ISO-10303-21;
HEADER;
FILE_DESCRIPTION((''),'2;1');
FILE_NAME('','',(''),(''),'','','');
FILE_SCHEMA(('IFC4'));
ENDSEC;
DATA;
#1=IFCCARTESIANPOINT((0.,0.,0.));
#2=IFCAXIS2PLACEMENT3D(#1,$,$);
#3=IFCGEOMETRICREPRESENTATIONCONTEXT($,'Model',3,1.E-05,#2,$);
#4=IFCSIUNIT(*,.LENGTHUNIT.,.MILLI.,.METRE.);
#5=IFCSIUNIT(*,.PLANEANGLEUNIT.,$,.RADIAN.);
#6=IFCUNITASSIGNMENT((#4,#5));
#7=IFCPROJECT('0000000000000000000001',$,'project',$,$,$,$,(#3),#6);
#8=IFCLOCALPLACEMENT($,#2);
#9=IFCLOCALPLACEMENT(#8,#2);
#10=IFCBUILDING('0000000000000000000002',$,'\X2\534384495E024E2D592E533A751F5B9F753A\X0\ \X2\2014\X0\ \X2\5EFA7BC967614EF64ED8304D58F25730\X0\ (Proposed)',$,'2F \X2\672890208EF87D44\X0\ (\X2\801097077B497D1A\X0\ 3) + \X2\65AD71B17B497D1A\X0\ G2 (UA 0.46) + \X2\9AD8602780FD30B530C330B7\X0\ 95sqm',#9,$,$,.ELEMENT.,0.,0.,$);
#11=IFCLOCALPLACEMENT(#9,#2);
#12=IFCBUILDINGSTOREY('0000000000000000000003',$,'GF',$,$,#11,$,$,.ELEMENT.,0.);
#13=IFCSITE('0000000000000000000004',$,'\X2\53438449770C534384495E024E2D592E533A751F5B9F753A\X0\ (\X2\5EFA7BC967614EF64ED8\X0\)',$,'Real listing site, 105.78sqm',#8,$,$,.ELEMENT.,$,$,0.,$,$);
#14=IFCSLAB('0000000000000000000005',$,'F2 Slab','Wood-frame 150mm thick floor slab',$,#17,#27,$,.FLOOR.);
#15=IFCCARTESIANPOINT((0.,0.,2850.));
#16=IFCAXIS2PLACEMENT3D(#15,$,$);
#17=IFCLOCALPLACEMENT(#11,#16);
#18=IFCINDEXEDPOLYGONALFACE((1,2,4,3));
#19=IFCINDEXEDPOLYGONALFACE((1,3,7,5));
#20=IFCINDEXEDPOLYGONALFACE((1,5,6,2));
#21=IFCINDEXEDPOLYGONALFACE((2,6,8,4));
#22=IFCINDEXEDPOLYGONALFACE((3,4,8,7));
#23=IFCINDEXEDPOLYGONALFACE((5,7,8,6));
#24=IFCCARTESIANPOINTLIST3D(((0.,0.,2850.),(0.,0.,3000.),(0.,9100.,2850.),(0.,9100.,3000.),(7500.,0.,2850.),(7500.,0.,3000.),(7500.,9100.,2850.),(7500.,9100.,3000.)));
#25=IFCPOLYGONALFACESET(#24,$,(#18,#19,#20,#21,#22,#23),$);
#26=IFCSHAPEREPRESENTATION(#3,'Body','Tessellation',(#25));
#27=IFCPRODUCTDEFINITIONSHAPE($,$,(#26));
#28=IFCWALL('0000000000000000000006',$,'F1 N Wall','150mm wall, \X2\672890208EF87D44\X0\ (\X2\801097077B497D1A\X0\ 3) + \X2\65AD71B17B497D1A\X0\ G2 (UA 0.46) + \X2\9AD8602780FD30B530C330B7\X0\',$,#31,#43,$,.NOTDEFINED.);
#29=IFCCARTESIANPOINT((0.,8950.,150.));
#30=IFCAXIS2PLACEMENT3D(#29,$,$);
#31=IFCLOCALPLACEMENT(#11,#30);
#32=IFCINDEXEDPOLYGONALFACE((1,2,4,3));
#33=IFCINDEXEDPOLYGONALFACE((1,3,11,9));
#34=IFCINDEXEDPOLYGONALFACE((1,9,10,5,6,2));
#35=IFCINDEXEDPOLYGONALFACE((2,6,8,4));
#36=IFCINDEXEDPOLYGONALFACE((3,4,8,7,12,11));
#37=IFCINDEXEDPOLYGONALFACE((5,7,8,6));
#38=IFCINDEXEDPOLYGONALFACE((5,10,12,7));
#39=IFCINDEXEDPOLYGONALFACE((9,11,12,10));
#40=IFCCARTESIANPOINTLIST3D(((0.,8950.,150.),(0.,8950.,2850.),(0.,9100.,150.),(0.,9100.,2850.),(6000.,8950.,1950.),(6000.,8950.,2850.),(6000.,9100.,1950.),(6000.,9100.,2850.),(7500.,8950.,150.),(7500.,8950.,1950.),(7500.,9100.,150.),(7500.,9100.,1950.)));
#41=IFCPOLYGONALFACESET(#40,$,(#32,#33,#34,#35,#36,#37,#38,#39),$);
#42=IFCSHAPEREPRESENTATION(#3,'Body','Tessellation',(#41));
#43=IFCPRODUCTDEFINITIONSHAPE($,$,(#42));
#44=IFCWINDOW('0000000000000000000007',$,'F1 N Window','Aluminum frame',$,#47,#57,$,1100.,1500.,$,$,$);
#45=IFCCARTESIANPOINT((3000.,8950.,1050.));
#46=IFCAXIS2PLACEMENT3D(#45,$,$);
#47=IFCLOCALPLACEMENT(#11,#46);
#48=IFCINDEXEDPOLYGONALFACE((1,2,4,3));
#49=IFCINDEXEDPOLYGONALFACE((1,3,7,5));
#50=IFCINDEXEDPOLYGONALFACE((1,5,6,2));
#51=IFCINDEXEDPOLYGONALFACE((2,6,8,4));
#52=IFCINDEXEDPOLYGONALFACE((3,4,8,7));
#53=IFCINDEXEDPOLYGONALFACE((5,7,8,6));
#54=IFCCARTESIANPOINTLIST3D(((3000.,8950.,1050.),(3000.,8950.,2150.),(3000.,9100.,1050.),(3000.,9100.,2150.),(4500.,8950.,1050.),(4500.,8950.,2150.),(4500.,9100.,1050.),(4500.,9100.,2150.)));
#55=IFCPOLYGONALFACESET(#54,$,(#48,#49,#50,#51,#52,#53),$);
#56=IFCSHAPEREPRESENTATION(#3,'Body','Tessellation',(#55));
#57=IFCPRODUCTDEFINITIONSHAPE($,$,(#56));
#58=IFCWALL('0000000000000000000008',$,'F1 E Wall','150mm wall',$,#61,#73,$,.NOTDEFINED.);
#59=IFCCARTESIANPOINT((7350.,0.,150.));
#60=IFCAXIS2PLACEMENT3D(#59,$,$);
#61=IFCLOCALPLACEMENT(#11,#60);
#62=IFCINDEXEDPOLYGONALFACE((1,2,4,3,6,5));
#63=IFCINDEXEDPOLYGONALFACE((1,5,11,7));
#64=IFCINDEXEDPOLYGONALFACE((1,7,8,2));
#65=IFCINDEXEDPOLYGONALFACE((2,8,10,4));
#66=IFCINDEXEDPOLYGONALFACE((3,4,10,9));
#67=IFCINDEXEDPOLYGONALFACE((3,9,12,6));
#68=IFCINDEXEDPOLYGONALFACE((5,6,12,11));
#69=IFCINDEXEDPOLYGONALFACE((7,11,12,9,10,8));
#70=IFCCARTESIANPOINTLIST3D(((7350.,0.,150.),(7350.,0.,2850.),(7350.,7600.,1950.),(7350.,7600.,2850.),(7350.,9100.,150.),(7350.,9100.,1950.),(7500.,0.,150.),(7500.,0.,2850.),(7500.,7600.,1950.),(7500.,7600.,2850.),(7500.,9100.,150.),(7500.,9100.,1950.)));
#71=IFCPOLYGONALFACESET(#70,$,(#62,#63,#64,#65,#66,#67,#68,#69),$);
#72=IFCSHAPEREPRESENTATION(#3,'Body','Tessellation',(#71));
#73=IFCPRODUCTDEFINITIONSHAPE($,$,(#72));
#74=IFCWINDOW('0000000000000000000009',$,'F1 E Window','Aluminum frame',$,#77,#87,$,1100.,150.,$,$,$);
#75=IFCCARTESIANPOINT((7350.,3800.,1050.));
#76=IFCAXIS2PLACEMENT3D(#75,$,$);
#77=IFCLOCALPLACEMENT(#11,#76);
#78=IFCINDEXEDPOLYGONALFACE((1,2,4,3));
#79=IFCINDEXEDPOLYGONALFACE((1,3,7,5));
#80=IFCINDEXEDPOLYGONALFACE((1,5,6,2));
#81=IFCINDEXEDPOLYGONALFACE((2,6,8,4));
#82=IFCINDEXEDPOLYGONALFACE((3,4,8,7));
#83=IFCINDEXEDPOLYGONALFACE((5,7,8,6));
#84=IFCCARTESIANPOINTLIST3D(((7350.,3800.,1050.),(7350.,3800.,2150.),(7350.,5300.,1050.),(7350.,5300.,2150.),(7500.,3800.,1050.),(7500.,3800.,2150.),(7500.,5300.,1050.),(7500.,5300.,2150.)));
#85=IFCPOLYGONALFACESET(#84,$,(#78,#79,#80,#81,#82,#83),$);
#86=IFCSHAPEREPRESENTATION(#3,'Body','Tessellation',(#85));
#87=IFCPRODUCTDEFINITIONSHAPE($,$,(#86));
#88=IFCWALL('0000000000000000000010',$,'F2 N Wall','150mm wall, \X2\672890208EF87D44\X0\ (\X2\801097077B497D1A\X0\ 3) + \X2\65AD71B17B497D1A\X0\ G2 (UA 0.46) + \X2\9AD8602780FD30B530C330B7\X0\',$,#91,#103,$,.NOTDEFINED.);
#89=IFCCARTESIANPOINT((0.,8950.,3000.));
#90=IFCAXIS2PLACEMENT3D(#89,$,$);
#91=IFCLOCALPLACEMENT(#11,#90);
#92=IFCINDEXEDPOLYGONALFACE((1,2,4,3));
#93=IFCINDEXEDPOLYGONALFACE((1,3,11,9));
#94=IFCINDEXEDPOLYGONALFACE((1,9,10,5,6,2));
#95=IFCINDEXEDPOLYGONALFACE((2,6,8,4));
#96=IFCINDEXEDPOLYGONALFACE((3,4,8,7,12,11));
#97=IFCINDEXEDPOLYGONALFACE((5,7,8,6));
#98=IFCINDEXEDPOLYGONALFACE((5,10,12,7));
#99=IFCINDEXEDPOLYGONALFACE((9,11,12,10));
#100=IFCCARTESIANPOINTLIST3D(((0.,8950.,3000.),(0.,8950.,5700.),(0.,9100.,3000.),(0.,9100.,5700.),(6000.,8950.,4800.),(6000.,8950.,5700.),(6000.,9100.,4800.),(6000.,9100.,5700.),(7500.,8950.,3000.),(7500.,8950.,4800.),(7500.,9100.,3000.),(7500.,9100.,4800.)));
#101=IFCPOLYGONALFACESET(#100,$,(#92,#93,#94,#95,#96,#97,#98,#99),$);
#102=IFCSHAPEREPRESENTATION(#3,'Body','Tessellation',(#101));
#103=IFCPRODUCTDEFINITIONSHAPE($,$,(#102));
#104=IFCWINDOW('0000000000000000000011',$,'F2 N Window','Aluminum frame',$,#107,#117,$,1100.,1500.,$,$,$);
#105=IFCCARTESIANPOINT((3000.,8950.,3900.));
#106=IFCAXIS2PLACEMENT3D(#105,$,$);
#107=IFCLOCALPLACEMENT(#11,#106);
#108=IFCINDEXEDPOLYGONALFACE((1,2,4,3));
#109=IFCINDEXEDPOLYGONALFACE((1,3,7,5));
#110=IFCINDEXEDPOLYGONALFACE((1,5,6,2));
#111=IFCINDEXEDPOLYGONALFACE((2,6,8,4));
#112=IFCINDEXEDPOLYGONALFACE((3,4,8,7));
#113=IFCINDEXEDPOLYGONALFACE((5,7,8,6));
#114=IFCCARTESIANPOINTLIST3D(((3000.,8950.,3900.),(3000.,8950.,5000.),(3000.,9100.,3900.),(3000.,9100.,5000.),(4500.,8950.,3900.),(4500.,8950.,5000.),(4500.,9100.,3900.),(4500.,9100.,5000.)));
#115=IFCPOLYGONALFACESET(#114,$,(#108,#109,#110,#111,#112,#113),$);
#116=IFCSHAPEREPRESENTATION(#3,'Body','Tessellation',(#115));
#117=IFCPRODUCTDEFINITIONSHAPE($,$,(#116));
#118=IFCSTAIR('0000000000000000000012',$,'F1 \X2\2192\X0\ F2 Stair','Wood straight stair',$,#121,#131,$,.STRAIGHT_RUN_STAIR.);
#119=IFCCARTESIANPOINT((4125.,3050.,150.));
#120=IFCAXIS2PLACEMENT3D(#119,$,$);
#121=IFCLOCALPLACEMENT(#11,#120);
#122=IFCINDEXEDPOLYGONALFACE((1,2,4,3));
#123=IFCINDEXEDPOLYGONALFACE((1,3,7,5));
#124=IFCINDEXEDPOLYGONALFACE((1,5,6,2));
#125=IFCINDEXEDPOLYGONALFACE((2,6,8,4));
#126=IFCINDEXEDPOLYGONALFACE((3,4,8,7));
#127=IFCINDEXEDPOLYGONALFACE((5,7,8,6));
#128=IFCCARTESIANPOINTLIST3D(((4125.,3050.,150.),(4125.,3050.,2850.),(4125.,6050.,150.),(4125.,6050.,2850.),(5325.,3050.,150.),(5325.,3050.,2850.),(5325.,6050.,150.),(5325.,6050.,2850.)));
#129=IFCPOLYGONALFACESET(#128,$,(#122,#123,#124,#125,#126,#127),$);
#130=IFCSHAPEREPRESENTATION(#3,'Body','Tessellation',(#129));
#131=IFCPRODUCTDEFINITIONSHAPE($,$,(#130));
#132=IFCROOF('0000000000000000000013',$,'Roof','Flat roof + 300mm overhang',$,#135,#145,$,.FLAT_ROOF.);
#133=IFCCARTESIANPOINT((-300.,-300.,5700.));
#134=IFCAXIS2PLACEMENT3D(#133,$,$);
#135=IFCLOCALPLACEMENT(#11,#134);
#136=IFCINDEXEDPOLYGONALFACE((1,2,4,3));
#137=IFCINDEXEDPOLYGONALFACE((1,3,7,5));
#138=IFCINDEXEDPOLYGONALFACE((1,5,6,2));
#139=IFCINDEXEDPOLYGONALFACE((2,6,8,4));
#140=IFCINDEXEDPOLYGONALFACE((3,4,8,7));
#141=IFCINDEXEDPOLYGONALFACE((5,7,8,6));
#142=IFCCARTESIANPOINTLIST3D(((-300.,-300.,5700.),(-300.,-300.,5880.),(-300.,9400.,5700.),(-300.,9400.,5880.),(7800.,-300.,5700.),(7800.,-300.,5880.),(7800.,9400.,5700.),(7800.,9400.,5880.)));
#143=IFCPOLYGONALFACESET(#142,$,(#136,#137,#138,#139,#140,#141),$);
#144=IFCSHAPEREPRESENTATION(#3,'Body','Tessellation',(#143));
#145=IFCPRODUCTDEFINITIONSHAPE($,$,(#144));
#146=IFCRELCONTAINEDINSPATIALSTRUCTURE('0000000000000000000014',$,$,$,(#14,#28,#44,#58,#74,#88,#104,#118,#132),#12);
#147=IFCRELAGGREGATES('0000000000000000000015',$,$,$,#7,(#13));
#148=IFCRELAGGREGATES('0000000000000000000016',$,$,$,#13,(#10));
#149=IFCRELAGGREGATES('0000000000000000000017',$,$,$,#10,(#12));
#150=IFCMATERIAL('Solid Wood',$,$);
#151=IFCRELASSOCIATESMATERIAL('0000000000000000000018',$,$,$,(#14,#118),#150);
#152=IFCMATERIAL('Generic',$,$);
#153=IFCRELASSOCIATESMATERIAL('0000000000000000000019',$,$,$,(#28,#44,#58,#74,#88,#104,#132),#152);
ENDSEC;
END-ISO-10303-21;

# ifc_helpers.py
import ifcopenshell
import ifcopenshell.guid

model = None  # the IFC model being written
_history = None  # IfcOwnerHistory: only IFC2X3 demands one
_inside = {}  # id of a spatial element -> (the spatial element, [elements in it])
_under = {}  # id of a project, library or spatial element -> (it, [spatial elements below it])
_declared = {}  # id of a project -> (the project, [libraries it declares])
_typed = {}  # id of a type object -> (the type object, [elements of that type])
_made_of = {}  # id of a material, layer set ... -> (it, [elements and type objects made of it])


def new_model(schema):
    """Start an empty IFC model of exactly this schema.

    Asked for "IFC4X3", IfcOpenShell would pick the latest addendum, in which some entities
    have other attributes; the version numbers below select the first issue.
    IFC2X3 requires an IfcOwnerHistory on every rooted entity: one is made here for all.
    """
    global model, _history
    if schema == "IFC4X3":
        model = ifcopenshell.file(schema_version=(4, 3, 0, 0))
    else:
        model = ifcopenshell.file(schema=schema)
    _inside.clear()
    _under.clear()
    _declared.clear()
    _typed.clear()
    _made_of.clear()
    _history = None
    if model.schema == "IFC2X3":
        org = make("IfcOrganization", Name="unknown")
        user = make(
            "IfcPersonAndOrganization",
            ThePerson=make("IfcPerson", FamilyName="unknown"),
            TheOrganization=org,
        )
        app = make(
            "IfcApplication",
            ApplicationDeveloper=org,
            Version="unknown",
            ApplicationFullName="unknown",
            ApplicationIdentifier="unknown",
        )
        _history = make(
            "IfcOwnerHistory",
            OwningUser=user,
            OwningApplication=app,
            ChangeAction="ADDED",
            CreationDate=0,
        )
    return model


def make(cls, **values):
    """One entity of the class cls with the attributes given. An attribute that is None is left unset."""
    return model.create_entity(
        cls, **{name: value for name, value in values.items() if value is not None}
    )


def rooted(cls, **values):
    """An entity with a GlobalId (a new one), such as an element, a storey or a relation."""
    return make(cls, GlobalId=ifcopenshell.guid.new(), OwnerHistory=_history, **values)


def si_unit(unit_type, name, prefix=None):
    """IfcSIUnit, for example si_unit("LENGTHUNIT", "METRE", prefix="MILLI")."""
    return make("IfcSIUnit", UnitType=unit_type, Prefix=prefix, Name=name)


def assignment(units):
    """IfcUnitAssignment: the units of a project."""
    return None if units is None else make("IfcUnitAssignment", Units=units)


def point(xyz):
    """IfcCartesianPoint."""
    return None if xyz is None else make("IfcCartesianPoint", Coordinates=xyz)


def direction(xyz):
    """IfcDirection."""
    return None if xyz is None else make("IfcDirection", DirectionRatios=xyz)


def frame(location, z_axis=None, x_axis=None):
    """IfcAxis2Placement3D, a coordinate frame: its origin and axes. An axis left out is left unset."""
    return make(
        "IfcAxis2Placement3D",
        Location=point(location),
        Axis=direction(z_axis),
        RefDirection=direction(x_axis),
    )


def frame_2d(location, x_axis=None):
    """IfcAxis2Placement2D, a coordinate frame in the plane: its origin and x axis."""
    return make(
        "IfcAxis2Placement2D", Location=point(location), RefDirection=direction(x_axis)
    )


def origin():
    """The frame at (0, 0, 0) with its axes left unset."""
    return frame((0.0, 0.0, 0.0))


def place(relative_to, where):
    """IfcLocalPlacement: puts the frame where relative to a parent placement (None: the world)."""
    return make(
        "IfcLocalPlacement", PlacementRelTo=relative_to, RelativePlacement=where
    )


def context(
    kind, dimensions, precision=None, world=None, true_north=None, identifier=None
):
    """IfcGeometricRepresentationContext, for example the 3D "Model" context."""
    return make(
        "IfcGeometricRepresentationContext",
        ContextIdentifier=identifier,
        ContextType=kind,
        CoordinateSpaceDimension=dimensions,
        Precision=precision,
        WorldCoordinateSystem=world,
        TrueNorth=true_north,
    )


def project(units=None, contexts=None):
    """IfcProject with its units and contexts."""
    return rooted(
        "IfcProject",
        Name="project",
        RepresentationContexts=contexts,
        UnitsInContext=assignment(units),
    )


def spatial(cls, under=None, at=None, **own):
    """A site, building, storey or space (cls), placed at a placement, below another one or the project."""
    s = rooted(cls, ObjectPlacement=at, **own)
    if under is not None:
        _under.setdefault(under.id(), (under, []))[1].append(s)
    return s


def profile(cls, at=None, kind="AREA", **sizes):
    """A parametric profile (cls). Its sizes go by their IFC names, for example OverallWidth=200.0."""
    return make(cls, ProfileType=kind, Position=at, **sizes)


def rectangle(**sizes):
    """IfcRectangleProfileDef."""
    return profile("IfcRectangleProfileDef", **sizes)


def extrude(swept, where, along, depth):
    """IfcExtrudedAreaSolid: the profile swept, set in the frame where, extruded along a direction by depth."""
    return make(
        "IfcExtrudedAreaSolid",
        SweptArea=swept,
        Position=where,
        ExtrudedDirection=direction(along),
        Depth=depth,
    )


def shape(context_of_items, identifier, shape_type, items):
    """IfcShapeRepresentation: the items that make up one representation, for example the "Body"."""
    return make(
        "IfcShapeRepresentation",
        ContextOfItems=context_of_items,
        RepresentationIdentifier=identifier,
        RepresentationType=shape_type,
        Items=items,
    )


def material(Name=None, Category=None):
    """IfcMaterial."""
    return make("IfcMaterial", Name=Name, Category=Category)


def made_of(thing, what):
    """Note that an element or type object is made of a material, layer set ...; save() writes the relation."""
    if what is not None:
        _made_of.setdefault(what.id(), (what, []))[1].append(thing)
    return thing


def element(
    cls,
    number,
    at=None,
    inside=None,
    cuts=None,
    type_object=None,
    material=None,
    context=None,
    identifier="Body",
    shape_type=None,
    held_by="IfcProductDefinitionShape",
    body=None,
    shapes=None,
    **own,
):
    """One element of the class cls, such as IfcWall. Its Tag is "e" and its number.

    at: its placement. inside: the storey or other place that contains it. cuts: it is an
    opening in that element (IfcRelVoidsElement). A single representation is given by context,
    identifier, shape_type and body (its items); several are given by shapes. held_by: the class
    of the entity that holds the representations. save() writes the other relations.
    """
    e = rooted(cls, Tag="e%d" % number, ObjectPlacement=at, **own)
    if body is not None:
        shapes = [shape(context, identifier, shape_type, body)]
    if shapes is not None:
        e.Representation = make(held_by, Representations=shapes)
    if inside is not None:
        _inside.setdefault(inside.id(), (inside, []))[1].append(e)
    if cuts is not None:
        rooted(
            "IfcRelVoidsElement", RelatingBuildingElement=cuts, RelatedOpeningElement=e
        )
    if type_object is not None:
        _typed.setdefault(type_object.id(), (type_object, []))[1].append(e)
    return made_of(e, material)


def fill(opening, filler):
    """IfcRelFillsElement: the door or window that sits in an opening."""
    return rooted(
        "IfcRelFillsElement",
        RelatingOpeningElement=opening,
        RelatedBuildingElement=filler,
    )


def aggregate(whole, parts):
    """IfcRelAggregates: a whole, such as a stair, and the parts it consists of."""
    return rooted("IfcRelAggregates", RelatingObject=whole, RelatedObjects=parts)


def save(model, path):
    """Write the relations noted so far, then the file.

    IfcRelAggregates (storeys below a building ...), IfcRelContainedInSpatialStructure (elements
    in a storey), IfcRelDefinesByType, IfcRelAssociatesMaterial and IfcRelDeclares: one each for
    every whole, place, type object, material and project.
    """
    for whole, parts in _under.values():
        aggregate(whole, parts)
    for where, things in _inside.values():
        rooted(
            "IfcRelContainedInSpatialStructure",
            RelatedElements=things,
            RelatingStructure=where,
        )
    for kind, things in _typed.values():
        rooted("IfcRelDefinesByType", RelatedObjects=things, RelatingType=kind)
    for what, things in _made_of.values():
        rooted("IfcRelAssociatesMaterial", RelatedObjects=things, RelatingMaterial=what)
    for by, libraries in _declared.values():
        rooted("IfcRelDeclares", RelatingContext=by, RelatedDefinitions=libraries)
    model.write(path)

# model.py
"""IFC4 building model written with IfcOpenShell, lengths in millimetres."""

from ifc_helpers import new_model, si_unit, frame, frame_2d, origin, place, context, project, spatial, rectangle, extrude, material, element, fill, save


model = new_model("IFC4")

# Units and contexts
model_context = context("Model", 3, precision=1e-05, world=origin())
ifc_project = project(units=[si_unit("LENGTHUNIT", "METRE", prefix="MILLI"), si_unit("PLANEANGLEUNIT", "RADIAN")], contexts=[model_context])

# Site, building, storey
site_placement = place(None, origin())
site = spatial("IfcSite", under=ifc_project, at=site_placement, Name="千葉県千葉市中央区生実町 (建築条件付)", ObjectType="Real listing site, 105.78sqm", CompositionType="ELEMENT", RefElevation=0.0)
building_placement = place(site_placement, origin())
building = spatial("IfcBuilding", under=site, at=building_placement, Name="千葉市中央区生実町 — 建築条件付き売地 (Proposed)", ObjectType="2F 木造軸組 (耐震等級 3) + 断熱等級 G2 (UA 0.46) + 高性能サッシ 95sqm", CompositionType="ELEMENT", ElevationOfRefHeight=0.0, ElevationOfTerrain=0.0)
storey_placement = place(building_placement, origin())
storey = spatial("IfcBuildingStorey", under=building, at=storey_placement, Name="GF", CompositionType="ELEMENT", Elevation=0.0)

# Slab
ifc_material_1 = material(Name="Solid Wood")
slab_1_placement = place(storey_placement, frame((0.0, 0.0, 2850.0)))
element("IfcSlab", 1, at=slab_1_placement, inside=storey, material=ifc_material_1, Name="F2 Slab", Description="Wood-frame 150mm thick floor slab", PredefinedType="FLOOR", context=model_context, shape_type="SweptSolid", body=[
    extrude(rectangle(XDim=7500.0, YDim=9100.0, at=frame_2d((3750.0, 4550.0))), frame((0.0, 0.0, 2850.0)), (0.0, 0.0, 1.0), 150.0),
])

# Wall, opening, window
ifc_material_2 = material(Name="Generic")
wall_1_placement = place(storey_placement, frame((0.0, 8950.0, 150.0)))
wall_1 = element("IfcWall", 2, at=wall_1_placement, inside=storey, material=ifc_material_2, Name="F1 N Wall", Description="150mm wall, 木造軸組 (耐震等級 3) + 断熱等級 G2 (UA 0.46) + 高性能サッシ", PredefinedType="NOTDEFINED", context=model_context, shape_type="SweptSolid", body=[
    extrude(rectangle(XDim=7500.0, YDim=150.0, at=frame_2d((3750.0, 75.0))), frame((0.0, 8950.0, 150.0)), (0.0, 0.0, 1.0), 2700.0),
])
opening_1_placement = place(storey_placement, frame((3000.0, 8950.0, 1050.0)))
opening_1 = element("IfcOpeningElement", 3, at=opening_1_placement, cuts=wall_1, PredefinedType="NOTDEFINED", context=model_context, shape_type="SweptSolid", body=[
    extrude(rectangle(XDim=1500.0, YDim=150.0, at=frame_2d((750.0, 75.0))), frame((3000.0, 8950.0, 1050.0)), (0.0, 0.0, 1.0), 1100.0),
])
window_1_placement = place(storey_placement, frame((3000.0, 8950.0, 1050.0)))
window_1 = element("IfcWindow", 4, at=window_1_placement, inside=storey, material=ifc_material_2, Name="F1 N Window", Description="Aluminum frame", OverallHeight=1100.0, OverallWidth=1500.0, context=model_context, shape_type="SweptSolid", body=[
    extrude(rectangle(XDim=1500.0, YDim=150.0, at=frame_2d((750.0, 75.0))), frame((3000.0, 8950.0, 1050.0)), (0.0, 0.0, 1.0), 1100.0),
])
fill(opening_1, window_1)

# Walls, openings, windows
wall_2_placement = place(storey_placement, frame((7350.0, 0.0, 150.0)))
wall_2 = element("IfcWall", 5, at=wall_2_placement, inside=storey, material=ifc_material_2, Name="F1 E Wall", Description="150mm wall", PredefinedType="NOTDEFINED", context=model_context, shape_type="SweptSolid", body=[
    extrude(rectangle(XDim=150.0, YDim=9100.0, at=frame_2d((75.0, 4550.0))), frame((7350.0, 0.0, 150.0)), (0.0, 0.0, 1.0), 2700.0),
])
opening_2_placement = place(storey_placement, frame((7350.0, 3800.0, 1050.0)))
opening_2 = element("IfcOpeningElement", 6, at=opening_2_placement, cuts=wall_2, PredefinedType="NOTDEFINED", context=model_context, shape_type="SweptSolid", body=[
    extrude(rectangle(XDim=150.0, YDim=1500.0, at=frame_2d((75.0, 750.0))), frame((7350.0, 3800.0, 1050.0)), (0.0, 0.0, 1.0), 1100.0),
])
window_2_placement = place(storey_placement, frame((7350.0, 3800.0, 1050.0)))
window_2 = element("IfcWindow", 7, at=window_2_placement, inside=storey, material=ifc_material_2, Name="F1 E Window", Description="Aluminum frame", OverallHeight=1100.0, OverallWidth=150.0, context=model_context, shape_type="SweptSolid", body=[
    extrude(rectangle(XDim=150.0, YDim=1500.0, at=frame_2d((75.0, 750.0))), frame((7350.0, 3800.0, 1050.0)), (0.0, 0.0, 1.0), 1100.0),
])
fill(opening_2, window_2)
wall_3_placement = place(storey_placement, frame((0.0, 8950.0, 3000.0)))
wall_3 = element("IfcWall", 8, at=wall_3_placement, inside=storey, material=ifc_material_2, Name="F2 N Wall", Description="150mm wall, 木造軸組 (耐震等級 3) + 断熱等級 G2 (UA 0.46) + 高性能サッシ", PredefinedType="NOTDEFINED", context=model_context, shape_type="SweptSolid", body=[
    extrude(rectangle(XDim=7500.0, YDim=150.0, at=frame_2d((3750.0, 75.0))), frame((0.0, 8950.0, 3000.0)), (0.0, 0.0, 1.0), 2700.0),
])
opening_3_placement = place(storey_placement, frame((3000.0, 8950.0, 3900.0)))
opening_3 = element("IfcOpeningElement", 9, at=opening_3_placement, cuts=wall_3, PredefinedType="NOTDEFINED", context=model_context, shape_type="SweptSolid", body=[
    extrude(rectangle(XDim=1500.0, YDim=150.0, at=frame_2d((750.0, 75.0))), frame((3000.0, 8950.0, 3900.0)), (0.0, 0.0, 1.0), 1100.0),
])
window_3_placement = place(storey_placement, frame((3000.0, 8950.0, 3900.0)))
window_3 = element("IfcWindow", 10, at=window_3_placement, inside=storey, material=ifc_material_2, Name="F2 N Window", Description="Aluminum frame", OverallHeight=1100.0, OverallWidth=1500.0, context=model_context, shape_type="SweptSolid", body=[
    extrude(rectangle(XDim=1500.0, YDim=150.0, at=frame_2d((750.0, 75.0))), frame((3000.0, 8950.0, 3900.0)), (0.0, 0.0, 1.0), 1100.0),
])
fill(opening_3, window_3)

# Stair
stair_placement = place(storey_placement, frame((4125.0, 3050.0, 150.0)))
element("IfcStair", 11, at=stair_placement, inside=storey, material=ifc_material_1, Name="F1 → F2 Stair", Description="Wood straight stair", PredefinedType="STRAIGHT_RUN_STAIR", context=model_context, shape_type="SweptSolid", body=[
    extrude(rectangle(XDim=1200.0, YDim=3000.0, at=frame_2d((600.0, 1500.0))), frame((4125.0, 3050.0, 150.0)), (0.0, 0.0, 1.0), 2700.0),
])

# Roof
roof_placement = place(storey_placement, frame((-300.0, -300.0, 5700.0)))
element("IfcRoof", 12, at=roof_placement, inside=storey, material=ifc_material_2, Name="Roof", Description="Flat roof + 300mm overhang", PredefinedType="FLAT_ROOF", context=model_context, shape_type="SweptSolid", body=[
    extrude(rectangle(XDim=8100.0, YDim=9700.0, at=frame_2d((4050.0, 4850.0))), frame((-300.0, -300.0, 5700.0)), (0.0, 0.0, 1.0), 180.0),
])

save(model, "model.ifc")
